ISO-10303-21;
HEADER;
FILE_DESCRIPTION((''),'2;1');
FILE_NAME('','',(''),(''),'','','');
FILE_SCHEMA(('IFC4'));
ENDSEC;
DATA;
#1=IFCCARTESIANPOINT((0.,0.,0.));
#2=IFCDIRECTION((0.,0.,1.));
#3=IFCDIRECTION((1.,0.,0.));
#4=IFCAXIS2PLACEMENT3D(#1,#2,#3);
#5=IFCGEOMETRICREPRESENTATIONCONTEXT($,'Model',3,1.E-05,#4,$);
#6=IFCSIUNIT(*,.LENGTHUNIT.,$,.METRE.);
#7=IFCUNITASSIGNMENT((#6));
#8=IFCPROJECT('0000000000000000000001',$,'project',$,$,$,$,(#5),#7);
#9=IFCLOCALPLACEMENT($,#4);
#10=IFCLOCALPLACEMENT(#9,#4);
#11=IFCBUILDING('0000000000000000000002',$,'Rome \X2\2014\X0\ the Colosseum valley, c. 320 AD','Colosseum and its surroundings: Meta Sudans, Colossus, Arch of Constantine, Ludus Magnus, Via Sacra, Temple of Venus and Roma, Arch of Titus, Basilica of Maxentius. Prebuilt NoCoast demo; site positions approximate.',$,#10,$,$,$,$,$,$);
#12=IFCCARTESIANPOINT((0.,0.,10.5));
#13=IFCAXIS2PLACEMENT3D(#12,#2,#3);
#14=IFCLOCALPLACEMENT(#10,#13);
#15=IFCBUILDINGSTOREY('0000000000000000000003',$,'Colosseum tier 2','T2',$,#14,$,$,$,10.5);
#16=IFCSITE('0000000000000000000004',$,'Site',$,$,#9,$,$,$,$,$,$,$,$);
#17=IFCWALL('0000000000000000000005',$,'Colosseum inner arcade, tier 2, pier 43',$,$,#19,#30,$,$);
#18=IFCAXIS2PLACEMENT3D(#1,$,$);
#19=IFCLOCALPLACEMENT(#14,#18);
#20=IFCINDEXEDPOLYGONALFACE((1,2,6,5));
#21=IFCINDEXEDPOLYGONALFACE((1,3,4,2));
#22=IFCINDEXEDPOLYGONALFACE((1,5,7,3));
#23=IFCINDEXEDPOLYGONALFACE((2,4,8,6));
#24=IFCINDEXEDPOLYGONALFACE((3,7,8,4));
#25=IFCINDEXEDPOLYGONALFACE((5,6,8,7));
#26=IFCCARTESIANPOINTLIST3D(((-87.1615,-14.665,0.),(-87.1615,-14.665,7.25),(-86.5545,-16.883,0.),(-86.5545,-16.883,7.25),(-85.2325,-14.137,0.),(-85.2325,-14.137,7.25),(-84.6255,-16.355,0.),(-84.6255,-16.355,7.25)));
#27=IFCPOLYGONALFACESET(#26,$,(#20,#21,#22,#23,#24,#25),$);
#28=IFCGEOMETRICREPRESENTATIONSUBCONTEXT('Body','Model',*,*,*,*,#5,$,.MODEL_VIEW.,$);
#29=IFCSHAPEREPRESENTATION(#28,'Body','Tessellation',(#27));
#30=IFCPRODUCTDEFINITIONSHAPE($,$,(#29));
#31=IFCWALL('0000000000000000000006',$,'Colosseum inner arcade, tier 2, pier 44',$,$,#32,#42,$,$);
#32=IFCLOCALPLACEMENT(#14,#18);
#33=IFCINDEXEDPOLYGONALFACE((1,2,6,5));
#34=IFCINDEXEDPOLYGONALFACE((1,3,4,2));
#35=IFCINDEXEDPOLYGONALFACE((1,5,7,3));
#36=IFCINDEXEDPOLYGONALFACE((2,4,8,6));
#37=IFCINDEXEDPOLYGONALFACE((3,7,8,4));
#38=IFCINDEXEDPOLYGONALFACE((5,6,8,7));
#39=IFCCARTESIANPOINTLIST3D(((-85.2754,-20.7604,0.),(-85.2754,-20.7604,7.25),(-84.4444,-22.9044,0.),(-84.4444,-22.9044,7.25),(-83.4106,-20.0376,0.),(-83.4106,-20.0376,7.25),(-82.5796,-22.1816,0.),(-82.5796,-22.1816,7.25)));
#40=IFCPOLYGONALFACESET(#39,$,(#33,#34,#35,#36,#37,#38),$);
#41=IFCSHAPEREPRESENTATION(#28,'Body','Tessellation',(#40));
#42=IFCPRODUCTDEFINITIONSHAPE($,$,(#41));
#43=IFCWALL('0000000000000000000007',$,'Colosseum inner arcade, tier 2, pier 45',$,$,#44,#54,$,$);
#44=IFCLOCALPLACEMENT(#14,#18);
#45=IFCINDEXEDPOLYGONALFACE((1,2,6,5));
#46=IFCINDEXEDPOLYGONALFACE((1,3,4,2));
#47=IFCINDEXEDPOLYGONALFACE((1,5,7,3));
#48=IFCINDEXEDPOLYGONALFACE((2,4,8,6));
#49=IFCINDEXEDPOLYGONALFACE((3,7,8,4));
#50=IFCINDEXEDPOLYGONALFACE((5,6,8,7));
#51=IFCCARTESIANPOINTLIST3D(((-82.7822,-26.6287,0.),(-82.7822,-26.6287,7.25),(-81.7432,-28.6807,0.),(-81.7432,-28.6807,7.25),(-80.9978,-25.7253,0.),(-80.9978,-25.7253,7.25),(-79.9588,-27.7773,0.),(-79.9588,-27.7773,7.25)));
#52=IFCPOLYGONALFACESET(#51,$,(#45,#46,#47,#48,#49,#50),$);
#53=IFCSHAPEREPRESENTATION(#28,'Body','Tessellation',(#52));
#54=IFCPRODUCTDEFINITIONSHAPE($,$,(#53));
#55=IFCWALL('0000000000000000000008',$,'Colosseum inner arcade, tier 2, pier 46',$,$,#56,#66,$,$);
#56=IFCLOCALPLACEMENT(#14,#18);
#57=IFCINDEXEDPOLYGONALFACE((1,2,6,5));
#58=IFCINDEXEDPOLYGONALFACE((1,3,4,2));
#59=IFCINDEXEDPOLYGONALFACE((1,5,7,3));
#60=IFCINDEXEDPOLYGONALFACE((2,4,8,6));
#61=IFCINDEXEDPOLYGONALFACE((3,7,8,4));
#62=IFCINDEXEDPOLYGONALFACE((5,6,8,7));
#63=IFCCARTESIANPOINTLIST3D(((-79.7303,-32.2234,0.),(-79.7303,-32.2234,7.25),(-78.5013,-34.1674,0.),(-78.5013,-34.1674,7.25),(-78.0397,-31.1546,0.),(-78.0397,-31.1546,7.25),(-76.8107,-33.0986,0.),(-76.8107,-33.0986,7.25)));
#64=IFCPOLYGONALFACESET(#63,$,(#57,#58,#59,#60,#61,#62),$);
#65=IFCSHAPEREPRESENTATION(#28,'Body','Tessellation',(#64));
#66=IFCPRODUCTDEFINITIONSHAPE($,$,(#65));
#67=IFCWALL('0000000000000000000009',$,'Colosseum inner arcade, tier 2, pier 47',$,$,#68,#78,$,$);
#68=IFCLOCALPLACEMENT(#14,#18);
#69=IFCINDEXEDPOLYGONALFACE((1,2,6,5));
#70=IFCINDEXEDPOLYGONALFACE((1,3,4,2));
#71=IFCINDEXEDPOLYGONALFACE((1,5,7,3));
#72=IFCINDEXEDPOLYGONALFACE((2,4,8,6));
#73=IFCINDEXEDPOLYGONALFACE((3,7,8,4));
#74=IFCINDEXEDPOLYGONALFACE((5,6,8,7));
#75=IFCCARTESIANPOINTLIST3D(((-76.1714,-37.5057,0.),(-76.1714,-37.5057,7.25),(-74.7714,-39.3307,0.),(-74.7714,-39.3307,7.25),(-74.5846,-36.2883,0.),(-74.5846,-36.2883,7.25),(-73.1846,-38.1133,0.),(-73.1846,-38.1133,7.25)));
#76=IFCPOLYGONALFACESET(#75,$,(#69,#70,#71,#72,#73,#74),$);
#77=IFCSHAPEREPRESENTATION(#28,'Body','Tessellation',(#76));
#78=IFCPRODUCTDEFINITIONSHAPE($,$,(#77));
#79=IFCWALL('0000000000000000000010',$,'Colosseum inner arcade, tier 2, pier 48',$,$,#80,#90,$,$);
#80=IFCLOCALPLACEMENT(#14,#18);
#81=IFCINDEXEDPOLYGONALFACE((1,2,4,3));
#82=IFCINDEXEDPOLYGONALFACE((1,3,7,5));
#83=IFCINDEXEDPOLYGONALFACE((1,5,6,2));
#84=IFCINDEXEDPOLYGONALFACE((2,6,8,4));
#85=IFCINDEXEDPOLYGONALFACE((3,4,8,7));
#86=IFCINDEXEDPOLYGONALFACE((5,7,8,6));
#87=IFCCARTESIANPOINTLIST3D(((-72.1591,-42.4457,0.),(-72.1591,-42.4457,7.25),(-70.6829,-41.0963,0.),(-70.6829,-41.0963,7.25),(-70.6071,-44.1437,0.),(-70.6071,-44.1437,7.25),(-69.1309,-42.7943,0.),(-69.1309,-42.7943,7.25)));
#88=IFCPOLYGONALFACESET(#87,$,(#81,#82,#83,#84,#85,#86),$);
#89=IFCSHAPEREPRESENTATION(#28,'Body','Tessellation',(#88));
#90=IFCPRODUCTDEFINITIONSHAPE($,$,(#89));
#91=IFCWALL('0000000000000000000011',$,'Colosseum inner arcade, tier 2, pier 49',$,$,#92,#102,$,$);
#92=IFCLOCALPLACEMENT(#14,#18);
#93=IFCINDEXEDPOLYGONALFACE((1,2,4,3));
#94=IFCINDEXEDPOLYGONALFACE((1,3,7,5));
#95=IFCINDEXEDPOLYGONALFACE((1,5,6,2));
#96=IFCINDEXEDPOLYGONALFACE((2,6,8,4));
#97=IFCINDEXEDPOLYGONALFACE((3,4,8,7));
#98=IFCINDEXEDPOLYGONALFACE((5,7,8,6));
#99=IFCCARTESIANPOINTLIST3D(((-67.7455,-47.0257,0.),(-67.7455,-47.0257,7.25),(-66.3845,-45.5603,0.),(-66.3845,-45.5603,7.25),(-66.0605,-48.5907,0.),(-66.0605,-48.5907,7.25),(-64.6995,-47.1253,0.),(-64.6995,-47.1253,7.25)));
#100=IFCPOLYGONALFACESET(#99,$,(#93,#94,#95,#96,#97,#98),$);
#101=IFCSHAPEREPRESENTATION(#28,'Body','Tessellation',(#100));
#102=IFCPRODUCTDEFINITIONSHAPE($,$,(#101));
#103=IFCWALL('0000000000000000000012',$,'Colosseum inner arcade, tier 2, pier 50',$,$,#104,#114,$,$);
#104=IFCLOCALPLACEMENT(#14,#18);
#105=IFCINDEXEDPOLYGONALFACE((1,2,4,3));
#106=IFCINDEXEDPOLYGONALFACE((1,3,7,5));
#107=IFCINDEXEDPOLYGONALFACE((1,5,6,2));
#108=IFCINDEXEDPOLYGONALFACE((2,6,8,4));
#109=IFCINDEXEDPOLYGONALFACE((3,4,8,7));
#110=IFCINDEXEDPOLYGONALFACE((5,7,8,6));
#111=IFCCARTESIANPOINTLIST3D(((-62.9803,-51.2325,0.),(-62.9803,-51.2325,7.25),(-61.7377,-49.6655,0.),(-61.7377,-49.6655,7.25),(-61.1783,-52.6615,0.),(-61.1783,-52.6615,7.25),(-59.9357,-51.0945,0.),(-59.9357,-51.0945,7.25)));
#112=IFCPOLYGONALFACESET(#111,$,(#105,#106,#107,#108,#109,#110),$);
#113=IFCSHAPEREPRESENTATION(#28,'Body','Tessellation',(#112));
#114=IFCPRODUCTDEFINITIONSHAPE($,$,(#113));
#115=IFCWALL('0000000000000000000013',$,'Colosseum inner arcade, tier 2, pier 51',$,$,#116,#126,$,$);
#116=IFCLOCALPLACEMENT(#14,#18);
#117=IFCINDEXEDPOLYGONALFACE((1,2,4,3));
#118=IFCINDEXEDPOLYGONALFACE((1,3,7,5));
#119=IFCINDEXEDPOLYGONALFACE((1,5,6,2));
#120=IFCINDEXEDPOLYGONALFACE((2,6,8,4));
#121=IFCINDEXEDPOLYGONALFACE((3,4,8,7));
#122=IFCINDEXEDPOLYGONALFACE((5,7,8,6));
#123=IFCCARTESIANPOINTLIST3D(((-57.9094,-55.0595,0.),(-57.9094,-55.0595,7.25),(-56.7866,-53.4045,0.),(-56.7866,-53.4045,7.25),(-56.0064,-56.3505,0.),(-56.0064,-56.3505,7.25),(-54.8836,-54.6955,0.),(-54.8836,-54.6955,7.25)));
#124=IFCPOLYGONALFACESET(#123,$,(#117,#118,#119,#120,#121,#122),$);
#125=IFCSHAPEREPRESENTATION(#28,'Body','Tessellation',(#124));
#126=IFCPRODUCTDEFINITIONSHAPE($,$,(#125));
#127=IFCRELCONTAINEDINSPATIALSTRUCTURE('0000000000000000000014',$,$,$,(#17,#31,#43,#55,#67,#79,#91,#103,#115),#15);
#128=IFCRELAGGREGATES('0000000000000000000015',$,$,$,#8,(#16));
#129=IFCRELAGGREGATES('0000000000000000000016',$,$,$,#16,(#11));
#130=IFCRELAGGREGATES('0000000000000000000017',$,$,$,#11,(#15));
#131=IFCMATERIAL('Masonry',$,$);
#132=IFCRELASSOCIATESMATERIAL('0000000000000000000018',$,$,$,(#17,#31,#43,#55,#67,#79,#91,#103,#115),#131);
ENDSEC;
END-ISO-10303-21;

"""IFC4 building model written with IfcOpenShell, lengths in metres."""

from ifc_helpers import new_model, si_unit, frame, origin_with_axes, place, context, subcontext, project, spatial, indexed_curve, outline, extrude, material, element, save


model = new_model("IFC4")

# Units and contexts
model_context = context("Model", 3, precision=1e-05, world=origin_with_axes())
body_context = subcontext(model_context, "Body", "Model", "MODEL_VIEW")
ifc_project = project(units=[si_unit("LENGTHUNIT", "METRE")], contexts=[model_context])

# Site, building, storey
site_placement = place(None, origin_with_axes())
site = spatial("IfcSite", under=ifc_project, at=site_placement, Name="Site")
building_placement = place(site_placement, origin_with_axes())
building = spatial("IfcBuilding", under=site, at=building_placement, Name="Rome — the Colosseum valley, c. 320 AD", Description="Colosseum and its surroundings: Meta Sudans, Colossus, Arch of Constantine, Ludus Magnus, Via Sacra, Temple of Venus and Roma, Arch of Titus, Basilica of Maxentius. Prebuilt NoCoast demo; site positions approximate.")
storey_placement = place(building_placement, frame((0.0, 0.0, 10.5), z_axis=(0.0, 0.0, 1.0), x_axis=(1.0, 0.0, 0.0)))
storey = spatial("IfcBuildingStorey", under=building, at=storey_placement, Name="Colosseum tier 2", Description="T2", Elevation=10.5)

# Walls
ifc_material = material(Name="Masonry")
wall_1_placement = place(storey_placement, frame((-86.197, -14.401, 0.0), z_axis=(0.0, 0.0, 1.0), x_axis=(0.263964, -0.964533, 0.0)))
element("IfcWall", 1, at=wall_1_placement, inside=storey, material=ifc_material, Name="Colosseum inner arcade, tier 2, pier 43", context=body_context, shape_type="SweptSolid", body=[
    extrude(outline(indexed_curve([(0.0, 0.0), (0.0, 2.0), (2.2996, 2.0), (2.2996, 0.0), (0.0, 0.0)], self_intersect=False)), frame((0.0, -1.0, 0.0), z_axis=(0.0, 0.0, 1.0), x_axis=(1.0, 0.0, 0.0)), (0.0, 0.0, 1.0), 7.25),
])
wall_2_placement = place(storey_placement, frame((-84.343, -20.399, 0.0), z_axis=(0.0, 0.0, 1.0), x_axis=(0.361397, -0.932412, 0.0)))
element("IfcWall", 2, at=wall_2_placement, inside=storey, material=ifc_material, Name="Colosseum inner arcade, tier 2, pier 44", context=body_context, shape_type="SweptSolid", body=[
    extrude(outline(indexed_curve([(0.0, 0.0), (0.0, 2.0), (2.2994, 2.0), (2.2994, 0.0), (0.0, 0.0)], self_intersect=False)), frame((0.0, -1.0, 0.0), z_axis=(0.0, 0.0, 1.0), x_axis=(1.0, 0.0, 0.0)), (0.0, 0.0, 1.0), 7.25),
])
wall_3_placement = place(storey_placement, frame((-81.89, -26.177, 0.0), z_axis=(0.0, 0.0, 1.0), x_axis=(0.45173, -0.892155, 0.0)))
element("IfcWall", 3, at=wall_3_placement, inside=storey, material=ifc_material, Name="Colosseum inner arcade, tier 2, pier 45", context=body_context, shape_type="SweptSolid", body=[
    extrude(outline(indexed_curve([(0.0, 0.0), (0.0, 2.0), (2.3, 2.0), (2.3, 0.0), (0.0, 0.0)], self_intersect=False)), frame((0.0, -1.0, 0.0), z_axis=(0.0, 0.0, 1.0), x_axis=(1.0, 0.0, 0.0)), (0.0, 0.0, 1.0), 7.25),
])
wall_4_placement = place(storey_placement, frame((-78.885, -31.689, 0.0), z_axis=(0.0, 0.0, 1.0), x_axis=(0.534369, -0.845251, 0.0)))
element("IfcWall", 4, at=wall_4_placement, inside=storey, material=ifc_material, Name="Colosseum inner arcade, tier 2, pier 46", context=body_context, shape_type="SweptSolid", body=[
    extrude(outline(indexed_curve([(0.0, 0.0), (0.0, 2.0), (2.2999, 2.0), (2.2999, 0.0), (0.0, 0.0)], self_intersect=False)), frame((0.0, -1.0, 0.0), z_axis=(0.0, 0.0, 1.0), x_axis=(1.0, 0.0, 0.0)), (0.0, 0.0, 1.0), 7.25),
])
wall_5_placement = place(storey_placement, frame((-75.378, -36.897, 0.0), z_axis=(0.0, 0.0, 1.0), x_axis=(0.60866, -0.793431, 0.0)))
element("IfcWall", 5, at=wall_5_placement, inside=storey, material=ifc_material, Name="Colosseum inner arcade, tier 2, pier 47", context=body_context, shape_type="SweptSolid", body=[
    extrude(outline(indexed_curve([(0.0, 0.0), (0.0, 2.0), (2.3001, 2.0), (2.3001, 0.0), (0.0, 0.0)], self_intersect=False)), frame((0.0, -1.0, 0.0), z_axis=(0.0, 0.0, 1.0), x_axis=(1.0, 0.0, 0.0)), (0.0, 0.0, 1.0), 7.25),
])
wall_6_placement = place(storey_placement, frame((-71.421, -41.771, 0.0), z_axis=(0.0, 0.0, 1.0), x_axis=(0.674661, -0.738128, 0.0)))
element("IfcWall", 6, at=wall_6_placement, inside=storey, material=ifc_material, Name="Colosseum inner arcade, tier 2, pier 48", context=body_context, shape_type="SweptSolid", body=[
    extrude(outline(indexed_curve([(0.0, 0.0), (0.0, 2.0), (2.3004, 2.0), (2.3004, 0.0), (0.0, 0.0)], self_intersect=False)), frame((0.0, -1.0, 0.0), z_axis=(0.0, 0.0, 1.0), x_axis=(1.0, 0.0, 0.0)), (0.0, 0.0, 1.0), 7.25),
])
wall_7_placement = place(storey_placement, frame((-67.065, -46.293, 0.0), z_axis=(0.0, 0.0, 1.0), x_axis=(0.732716, -0.680534, 0.0)))
element("IfcWall", 7, at=wall_7_placement, inside=storey, material=ifc_material, Name="Colosseum inner arcade, tier 2, pier 49", context=body_context, shape_type="SweptSolid", body=[
    extrude(outline(indexed_curve([(0.0, 0.0), (0.0, 2.0), (2.2997, 2.0), (2.2997, 0.0), (0.0, 0.0)], self_intersect=False)), frame((0.0, -1.0, 0.0), z_axis=(0.0, 0.0, 1.0), x_axis=(1.0, 0.0, 0.0)), (0.0, 0.0, 1.0), 7.25),
])
wall_8_placement = place(storey_placement, frame((-62.359, -50.449, 0.0), z_axis=(0.0, 0.0, 1.0), x_axis=(0.783534, -0.621349, 0.0)))
element("IfcWall", 8, at=wall_8_placement, inside=storey, material=ifc_material, Name="Colosseum inner arcade, tier 2, pier 50", context=body_context, shape_type="SweptSolid", body=[
    extrude(outline(indexed_curve([(0.0, 0.0), (0.0, 2.0), (2.2998, 2.0), (2.2998, 0.0), (0.0, 0.0)], self_intersect=False)), frame((0.0, -1.0, 0.0), z_axis=(0.0, 0.0, 1.0), x_axis=(1.0, 0.0, 0.0)), (0.0, 0.0, 1.0), 7.25),
])
wall_9_placement = place(storey_placement, frame((-57.348, -54.232, 0.0), z_axis=(0.0, 0.0, 1.0), x_axis=(0.827541, -0.561406, 0.0)))
element("IfcWall", 9, at=wall_9_placement, inside=storey, material=ifc_material, Name="Colosseum inner arcade, tier 2, pier 51", context=body_context, shape_type="SweptSolid", body=[
    extrude(outline(indexed_curve([(0.0, 0.0), (0.0, 2.0), (2.2996, 2.0), (2.2996, 0.0), (0.0, 0.0)], self_intersect=False)), frame((0.0, -1.0, 0.0), z_axis=(0.0, 0.0, 1.0), x_axis=(1.0, 0.0, 0.0)), (0.0, 0.0, 1.0), 7.25),
])

save(model, "model.ifc")
